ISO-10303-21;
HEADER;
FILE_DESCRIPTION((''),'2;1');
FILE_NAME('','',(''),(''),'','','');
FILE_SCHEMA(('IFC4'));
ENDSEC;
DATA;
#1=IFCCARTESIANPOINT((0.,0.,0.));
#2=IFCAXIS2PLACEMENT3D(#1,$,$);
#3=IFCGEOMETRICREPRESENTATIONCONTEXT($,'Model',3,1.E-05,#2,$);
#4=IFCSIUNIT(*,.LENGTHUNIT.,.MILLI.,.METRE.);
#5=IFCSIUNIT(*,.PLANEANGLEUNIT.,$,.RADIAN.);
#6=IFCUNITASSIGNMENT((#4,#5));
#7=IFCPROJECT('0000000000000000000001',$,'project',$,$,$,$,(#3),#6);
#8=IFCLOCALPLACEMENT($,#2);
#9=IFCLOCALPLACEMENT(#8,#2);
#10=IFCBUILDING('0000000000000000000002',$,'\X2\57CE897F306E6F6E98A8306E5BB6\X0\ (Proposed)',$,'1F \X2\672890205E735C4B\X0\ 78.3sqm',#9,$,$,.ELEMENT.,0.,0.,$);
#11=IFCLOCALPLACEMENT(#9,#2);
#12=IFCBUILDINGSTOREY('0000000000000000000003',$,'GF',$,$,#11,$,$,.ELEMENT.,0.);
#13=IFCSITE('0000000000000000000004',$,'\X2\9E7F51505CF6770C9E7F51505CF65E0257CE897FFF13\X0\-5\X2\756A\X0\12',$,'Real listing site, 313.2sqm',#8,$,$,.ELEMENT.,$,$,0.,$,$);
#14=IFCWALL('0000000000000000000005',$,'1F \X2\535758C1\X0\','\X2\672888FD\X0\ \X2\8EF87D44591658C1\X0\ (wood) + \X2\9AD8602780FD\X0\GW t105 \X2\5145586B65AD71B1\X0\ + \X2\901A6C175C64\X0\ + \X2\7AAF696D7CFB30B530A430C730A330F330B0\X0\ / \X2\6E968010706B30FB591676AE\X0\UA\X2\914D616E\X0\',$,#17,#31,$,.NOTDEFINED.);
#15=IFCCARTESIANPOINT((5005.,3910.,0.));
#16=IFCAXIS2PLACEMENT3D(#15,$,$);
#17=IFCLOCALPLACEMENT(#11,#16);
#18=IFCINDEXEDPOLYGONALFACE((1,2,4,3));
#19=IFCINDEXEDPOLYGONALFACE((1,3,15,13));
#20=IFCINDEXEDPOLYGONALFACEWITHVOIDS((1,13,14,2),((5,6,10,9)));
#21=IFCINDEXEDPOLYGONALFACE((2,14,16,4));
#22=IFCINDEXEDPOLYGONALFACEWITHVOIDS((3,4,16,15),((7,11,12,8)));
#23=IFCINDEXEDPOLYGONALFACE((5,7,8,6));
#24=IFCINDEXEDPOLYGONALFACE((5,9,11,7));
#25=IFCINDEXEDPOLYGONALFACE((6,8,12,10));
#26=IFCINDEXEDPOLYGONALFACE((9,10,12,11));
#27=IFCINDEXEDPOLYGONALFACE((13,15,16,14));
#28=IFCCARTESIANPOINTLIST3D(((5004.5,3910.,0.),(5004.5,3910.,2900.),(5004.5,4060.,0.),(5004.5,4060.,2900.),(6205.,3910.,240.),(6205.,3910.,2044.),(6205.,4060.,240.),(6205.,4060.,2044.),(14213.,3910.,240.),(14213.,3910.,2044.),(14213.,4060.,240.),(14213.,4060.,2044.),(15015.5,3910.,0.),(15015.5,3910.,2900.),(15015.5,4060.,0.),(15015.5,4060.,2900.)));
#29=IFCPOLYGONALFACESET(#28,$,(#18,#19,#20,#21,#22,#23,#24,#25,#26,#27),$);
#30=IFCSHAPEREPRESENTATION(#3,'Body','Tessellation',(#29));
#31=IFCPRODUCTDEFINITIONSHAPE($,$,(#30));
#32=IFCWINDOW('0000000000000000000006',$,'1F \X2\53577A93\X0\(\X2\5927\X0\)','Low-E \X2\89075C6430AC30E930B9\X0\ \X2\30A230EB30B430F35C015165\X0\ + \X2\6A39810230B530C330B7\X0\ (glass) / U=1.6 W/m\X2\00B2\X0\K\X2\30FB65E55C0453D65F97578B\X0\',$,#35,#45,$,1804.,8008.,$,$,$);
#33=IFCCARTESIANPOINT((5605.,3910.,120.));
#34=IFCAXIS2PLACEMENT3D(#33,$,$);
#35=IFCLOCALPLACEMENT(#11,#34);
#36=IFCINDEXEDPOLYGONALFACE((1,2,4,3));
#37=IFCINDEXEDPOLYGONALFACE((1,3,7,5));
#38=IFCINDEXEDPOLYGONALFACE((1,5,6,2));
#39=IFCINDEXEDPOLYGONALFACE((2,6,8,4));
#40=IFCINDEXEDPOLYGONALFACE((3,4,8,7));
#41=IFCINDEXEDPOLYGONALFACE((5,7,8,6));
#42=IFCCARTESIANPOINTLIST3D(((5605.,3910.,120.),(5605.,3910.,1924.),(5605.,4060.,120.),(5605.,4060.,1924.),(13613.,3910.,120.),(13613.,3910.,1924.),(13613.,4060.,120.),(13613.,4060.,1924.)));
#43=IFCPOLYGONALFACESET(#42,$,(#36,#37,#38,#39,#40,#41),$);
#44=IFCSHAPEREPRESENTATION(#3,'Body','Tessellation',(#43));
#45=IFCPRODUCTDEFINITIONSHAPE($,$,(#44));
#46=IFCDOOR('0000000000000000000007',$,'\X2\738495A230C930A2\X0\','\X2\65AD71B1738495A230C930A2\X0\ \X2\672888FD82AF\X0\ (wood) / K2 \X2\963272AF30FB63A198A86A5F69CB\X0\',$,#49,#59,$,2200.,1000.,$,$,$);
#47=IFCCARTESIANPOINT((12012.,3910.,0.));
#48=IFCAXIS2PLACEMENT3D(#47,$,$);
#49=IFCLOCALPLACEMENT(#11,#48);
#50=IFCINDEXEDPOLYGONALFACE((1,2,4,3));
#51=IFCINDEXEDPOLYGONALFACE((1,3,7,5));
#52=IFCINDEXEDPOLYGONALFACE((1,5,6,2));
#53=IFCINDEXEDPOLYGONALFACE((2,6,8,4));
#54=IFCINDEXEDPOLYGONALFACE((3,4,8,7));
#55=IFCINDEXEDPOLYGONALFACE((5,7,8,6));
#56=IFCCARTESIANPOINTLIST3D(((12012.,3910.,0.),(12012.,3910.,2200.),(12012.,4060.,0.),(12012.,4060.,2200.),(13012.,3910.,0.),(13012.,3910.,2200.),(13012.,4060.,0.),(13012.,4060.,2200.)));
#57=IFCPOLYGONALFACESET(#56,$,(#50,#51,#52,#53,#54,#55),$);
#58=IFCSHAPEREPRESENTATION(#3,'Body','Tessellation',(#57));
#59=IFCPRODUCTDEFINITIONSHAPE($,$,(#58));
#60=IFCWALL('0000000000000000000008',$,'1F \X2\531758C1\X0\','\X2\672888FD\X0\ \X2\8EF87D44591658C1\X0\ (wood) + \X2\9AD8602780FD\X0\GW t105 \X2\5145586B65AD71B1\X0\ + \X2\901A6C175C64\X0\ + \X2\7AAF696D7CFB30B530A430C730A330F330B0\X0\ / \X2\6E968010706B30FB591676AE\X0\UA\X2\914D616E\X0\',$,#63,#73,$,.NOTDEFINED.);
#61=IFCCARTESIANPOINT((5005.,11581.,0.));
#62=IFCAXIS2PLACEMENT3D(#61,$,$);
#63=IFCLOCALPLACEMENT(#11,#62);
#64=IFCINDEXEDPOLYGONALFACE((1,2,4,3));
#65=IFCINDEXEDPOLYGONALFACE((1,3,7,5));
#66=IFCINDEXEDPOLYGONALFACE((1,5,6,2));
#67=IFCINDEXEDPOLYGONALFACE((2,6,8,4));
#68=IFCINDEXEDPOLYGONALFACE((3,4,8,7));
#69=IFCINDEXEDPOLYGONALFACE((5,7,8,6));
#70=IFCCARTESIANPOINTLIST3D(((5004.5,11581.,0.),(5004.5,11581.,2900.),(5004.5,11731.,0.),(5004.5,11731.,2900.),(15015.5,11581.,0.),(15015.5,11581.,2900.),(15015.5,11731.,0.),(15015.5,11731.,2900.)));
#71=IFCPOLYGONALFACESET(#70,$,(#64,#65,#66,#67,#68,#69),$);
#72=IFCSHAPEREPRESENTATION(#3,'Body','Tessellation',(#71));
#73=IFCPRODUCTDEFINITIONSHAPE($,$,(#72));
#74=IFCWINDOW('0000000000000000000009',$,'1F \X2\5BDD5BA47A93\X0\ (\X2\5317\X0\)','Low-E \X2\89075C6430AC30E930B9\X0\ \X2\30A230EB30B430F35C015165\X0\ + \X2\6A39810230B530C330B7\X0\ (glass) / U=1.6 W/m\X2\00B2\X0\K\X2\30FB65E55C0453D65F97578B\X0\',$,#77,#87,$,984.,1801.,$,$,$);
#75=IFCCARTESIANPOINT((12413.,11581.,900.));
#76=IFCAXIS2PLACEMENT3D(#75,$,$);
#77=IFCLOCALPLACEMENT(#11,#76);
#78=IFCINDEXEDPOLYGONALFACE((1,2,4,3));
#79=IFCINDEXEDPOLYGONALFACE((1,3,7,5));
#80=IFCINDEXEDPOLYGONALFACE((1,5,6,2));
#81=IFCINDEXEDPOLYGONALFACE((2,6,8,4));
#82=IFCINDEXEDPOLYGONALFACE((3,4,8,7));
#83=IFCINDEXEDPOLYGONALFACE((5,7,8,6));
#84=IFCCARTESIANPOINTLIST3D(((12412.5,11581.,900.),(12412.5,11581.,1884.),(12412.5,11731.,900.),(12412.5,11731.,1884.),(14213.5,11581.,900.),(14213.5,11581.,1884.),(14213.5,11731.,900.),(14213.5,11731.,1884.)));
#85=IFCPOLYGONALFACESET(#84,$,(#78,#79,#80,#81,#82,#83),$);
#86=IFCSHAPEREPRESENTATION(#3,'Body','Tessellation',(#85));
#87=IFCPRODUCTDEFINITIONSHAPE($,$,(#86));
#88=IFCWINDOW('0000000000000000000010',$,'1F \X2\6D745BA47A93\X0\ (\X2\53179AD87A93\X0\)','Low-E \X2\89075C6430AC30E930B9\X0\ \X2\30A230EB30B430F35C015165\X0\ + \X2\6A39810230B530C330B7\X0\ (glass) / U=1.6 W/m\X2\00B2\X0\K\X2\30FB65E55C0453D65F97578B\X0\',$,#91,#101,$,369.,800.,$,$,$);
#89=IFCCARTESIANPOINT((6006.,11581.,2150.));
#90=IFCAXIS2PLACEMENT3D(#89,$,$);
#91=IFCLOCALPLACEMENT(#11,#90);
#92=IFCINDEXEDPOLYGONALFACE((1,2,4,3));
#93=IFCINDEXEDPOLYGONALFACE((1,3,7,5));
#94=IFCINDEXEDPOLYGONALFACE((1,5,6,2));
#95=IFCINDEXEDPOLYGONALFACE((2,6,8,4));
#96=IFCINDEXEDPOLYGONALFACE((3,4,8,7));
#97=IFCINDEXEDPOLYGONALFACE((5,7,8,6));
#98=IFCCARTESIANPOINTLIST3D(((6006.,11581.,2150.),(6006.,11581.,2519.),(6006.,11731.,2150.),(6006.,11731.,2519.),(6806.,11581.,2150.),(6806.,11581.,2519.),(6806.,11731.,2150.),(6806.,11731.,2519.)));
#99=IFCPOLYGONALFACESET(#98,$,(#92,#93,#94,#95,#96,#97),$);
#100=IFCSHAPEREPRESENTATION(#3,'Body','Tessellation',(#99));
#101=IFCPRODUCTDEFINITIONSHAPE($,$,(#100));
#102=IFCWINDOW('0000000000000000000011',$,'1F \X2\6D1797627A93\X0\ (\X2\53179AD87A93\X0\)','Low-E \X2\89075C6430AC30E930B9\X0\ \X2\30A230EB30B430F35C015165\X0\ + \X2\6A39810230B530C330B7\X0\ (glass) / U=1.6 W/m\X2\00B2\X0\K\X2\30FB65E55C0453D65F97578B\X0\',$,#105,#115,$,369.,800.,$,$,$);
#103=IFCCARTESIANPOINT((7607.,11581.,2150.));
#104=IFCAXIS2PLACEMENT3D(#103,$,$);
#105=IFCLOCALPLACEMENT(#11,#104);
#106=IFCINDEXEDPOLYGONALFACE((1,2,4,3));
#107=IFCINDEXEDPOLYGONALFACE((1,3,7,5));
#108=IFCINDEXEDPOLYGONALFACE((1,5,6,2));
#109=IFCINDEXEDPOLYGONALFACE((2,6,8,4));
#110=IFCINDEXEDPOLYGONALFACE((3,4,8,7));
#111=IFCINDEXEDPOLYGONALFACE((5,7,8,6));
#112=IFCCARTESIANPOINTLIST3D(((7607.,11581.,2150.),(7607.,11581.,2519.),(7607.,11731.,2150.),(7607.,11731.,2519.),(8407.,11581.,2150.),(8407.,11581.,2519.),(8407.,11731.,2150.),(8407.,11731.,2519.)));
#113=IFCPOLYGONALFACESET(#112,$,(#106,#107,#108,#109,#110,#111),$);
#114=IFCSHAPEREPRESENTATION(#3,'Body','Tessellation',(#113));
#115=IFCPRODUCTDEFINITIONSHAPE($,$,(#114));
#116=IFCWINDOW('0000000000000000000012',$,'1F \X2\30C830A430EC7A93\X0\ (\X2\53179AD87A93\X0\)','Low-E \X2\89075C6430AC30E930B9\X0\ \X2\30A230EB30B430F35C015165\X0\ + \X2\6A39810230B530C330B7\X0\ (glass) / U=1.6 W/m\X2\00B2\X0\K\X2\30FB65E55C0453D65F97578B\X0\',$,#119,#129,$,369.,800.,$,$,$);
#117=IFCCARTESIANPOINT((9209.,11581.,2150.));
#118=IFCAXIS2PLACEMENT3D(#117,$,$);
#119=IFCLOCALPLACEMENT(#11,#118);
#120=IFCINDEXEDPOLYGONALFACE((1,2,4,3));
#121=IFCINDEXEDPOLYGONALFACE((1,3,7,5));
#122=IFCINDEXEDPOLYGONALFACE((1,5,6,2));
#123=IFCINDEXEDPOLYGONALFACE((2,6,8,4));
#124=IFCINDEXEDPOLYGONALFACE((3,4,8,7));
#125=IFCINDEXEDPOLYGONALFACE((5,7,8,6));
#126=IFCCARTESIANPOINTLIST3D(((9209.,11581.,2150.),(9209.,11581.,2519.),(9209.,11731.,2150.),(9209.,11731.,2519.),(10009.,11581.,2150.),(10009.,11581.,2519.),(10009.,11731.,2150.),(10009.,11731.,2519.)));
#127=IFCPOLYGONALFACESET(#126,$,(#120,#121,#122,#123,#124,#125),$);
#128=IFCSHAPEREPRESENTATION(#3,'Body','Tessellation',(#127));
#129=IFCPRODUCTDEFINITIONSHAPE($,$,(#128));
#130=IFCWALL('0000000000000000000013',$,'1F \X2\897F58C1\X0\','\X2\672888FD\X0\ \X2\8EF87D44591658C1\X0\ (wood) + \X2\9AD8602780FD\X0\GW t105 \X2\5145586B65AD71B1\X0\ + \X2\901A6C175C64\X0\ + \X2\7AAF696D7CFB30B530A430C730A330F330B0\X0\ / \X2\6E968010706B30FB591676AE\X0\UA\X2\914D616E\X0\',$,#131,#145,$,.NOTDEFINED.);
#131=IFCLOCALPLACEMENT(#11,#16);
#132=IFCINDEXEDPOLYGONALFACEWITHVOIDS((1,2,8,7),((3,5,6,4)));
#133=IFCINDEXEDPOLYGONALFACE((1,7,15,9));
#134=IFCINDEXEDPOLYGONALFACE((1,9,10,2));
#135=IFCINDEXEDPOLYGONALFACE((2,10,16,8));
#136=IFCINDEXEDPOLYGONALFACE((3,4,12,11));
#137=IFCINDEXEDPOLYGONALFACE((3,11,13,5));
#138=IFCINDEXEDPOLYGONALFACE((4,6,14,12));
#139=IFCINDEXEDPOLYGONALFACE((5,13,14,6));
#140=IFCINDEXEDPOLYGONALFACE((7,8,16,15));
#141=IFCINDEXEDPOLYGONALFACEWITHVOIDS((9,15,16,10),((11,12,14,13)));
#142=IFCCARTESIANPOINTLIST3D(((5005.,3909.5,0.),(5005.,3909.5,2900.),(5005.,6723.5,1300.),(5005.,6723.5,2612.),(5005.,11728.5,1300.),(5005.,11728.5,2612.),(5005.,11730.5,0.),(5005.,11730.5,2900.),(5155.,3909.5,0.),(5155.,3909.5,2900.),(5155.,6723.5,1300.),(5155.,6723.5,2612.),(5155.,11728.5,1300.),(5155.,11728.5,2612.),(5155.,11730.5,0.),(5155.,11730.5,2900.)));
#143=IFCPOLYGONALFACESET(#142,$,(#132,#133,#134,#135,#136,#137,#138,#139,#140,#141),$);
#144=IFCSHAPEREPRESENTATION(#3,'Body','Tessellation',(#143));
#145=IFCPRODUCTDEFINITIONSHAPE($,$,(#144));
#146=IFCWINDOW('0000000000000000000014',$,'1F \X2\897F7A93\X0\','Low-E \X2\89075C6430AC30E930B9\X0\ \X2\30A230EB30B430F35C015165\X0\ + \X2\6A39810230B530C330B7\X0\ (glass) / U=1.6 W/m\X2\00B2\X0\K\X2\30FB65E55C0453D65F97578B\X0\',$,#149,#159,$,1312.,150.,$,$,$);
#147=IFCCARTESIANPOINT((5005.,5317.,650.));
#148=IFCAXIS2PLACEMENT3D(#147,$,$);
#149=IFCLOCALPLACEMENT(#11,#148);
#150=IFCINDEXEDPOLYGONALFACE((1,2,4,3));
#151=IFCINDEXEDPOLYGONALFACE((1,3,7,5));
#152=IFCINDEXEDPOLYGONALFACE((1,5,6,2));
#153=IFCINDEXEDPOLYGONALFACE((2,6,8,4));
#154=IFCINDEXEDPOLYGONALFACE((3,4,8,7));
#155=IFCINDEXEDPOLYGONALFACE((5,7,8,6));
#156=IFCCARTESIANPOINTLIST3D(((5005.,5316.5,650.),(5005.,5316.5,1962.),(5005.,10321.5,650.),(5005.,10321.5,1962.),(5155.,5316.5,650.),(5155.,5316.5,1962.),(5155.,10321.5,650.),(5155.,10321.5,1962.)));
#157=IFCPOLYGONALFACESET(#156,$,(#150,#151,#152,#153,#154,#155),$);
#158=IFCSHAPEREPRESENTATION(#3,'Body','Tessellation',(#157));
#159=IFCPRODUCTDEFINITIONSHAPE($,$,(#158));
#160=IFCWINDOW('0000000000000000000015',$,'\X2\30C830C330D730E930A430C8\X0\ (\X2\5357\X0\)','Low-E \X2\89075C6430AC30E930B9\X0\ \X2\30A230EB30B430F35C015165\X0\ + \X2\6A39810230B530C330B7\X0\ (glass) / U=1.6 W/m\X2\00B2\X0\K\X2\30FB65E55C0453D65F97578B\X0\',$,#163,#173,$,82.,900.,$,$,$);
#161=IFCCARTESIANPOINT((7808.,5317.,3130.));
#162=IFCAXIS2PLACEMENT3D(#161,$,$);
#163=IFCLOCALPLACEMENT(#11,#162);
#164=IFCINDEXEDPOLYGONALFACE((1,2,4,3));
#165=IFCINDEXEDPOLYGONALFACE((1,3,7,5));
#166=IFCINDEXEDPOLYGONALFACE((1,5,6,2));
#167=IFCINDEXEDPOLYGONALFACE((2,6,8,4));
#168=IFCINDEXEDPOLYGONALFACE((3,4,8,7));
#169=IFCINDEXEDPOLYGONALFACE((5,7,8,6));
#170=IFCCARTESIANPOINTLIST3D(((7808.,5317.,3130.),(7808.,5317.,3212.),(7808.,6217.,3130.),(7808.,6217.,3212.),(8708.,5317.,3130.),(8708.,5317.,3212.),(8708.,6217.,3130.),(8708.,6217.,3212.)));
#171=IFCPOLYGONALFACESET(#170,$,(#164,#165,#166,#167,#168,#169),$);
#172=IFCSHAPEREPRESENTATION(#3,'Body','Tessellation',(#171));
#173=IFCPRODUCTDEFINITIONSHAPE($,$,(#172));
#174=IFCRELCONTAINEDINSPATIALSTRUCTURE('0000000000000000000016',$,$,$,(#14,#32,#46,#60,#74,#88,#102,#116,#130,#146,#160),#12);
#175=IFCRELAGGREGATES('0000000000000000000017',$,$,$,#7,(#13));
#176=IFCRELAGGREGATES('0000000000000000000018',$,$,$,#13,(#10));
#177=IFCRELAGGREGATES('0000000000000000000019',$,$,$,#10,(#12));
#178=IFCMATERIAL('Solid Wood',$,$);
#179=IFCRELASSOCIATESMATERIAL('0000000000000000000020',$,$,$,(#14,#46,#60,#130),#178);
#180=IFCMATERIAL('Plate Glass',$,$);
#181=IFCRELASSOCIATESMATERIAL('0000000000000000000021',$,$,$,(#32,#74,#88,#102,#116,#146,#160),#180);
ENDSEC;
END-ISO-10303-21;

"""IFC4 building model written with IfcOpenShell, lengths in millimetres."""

from ifc_helpers import new_model, si_unit, frame, frame_2d, origin, place, context, project, spatial, rectangle, extrude, material, element, fill, save


model = new_model("IFC4")

# Units and contexts
model_context = context("Model", 3, precision=1e-05, world=origin())
ifc_project = project(units=[si_unit("LENGTHUNIT", "METRE", prefix="MILLI"), si_unit("PLANEANGLEUNIT", "RADIAN")], contexts=[model_context])

# Site, building, storey
site_placement = place(None, origin())
site = spatial("IfcSite", under=ifc_project, at=site_placement, Name="鹿児島県鹿児島市城西３-5番12", ObjectType="Real listing site, 313.2sqm", CompositionType="ELEMENT", RefElevation=0.0)
building_placement = place(site_placement, origin())
building = spatial("IfcBuilding", under=site, at=building_placement, Name="城西の潮風の家 (Proposed)", ObjectType="1F 木造平屋 78.3sqm", CompositionType="ELEMENT", ElevationOfRefHeight=0.0, ElevationOfTerrain=0.0)
storey_placement = place(building_placement, origin())
storey = spatial("IfcBuildingStorey", under=building, at=storey_placement, Name="GF", CompositionType="ELEMENT", Elevation=0.0)

# Shared definitions
ifc_material_1 = material(Name="Solid Wood")

# Wall, openings, window, door
wall_1_placement = place(storey_placement, frame((5005.0, 3910.0, 0.0)))
wall_1 = element("IfcWall", 1, at=wall_1_placement, inside=storey, material=ifc_material_1, Name="1F 南壁", Description="木製 軸組外壁 (wood) + 高性能GW t105 充填断熱 + 通気層 + 窯業系サイディング / 準耐火・外皮UA配慮", PredefinedType="NOTDEFINED", context=model_context, shape_type="SweptSolid", body=[
    extrude(rectangle(XDim=10011.0, YDim=150.0, at=frame_2d((5005.0, 75.0))), frame((5005.0, 3910.0, 0.0)), (0.0, 0.0, 1.0), 2900.0),
])
opening_1_placement = place(storey_placement, frame((5605.0, 3910.0, 120.0)))
opening_1 = element("IfcOpeningElement", 2, at=opening_1_placement, cuts=wall_1, PredefinedType="NOTDEFINED", context=model_context, shape_type="SweptSolid", body=[
    extrude(rectangle(XDim=8008.0, YDim=150.0, at=frame_2d((4004.0, 75.0))), frame((5605.0, 3910.0, 120.0)), (0.0, 0.0, 1.0), 1804.0),
])
opening_2_placement = place(storey_placement, frame((12012.0, 3910.0, 0.0)))
opening_2 = element("IfcOpeningElement", 3, at=opening_2_placement, cuts=wall_1, PredefinedType="NOTDEFINED", context=model_context, shape_type="SweptSolid", body=[
    extrude(rectangle(XDim=1000.0, YDim=150.0, at=frame_2d((500.0, 75.0))), frame((12012.0, 3910.0, 0.0)), (0.0, 0.0, 1.0), 2200.0),
])
ifc_material_2 = material(Name="Plate Glass")
window_1_placement = place(storey_placement, frame((5605.0, 3910.0, 120.0)))
window_1 = element("IfcWindow", 4, at=window_1_placement, inside=storey, material=ifc_material_2, Name="1F 南窓(大)", Description="Low-E 複層ガラス アルゴン封入 + 樹脂サッシ (glass) / U=1.6 W/m²K・日射取得型", OverallHeight=1804.0, OverallWidth=8008.0, context=model_context, shape_type="SweptSolid", body=[
    extrude(rectangle(XDim=8008.0, YDim=150.0, at=frame_2d((4004.0, 75.0))), frame((5605.0, 3910.0, 120.0)), (0.0, 0.0, 1.0), 1804.0),
])
fill(opening_1, window_1)
door_1_placement = place(storey_placement, frame((12012.0, 3910.0, 0.0)))
door_1 = element("IfcDoor", 5, at=door_1_placement, inside=storey, material=ifc_material_1, Name="玄関ドア", Description="断熱玄関ドア 木製芯 (wood) / K2 防犯・採風機構", OverallHeight=2200.0, OverallWidth=1000.0, context=model_context, shape_type="SweptSolid", body=[
    extrude(rectangle(XDim=1000.0, YDim=150.0, at=frame_2d((500.0, 75.0))), frame((12012.0, 3910.0, 0.0)), (0.0, 0.0, 1.0), 2200.0),
])
fill(opening_2, door_1)

# Wall, openings, windows
wall_2_placement = place(storey_placement, frame((5005.0, 11581.0, 0.0)))
wall_2 = element("IfcWall", 6, at=wall_2_placement, inside=storey, material=ifc_material_1, Name="1F 北壁", Description="木製 軸組外壁 (wood) + 高性能GW t105 充填断熱 + 通気層 + 窯業系サイディング / 準耐火・外皮UA配慮", PredefinedType="NOTDEFINED", context=model_context, shape_type="SweptSolid", body=[
    extrude(rectangle(XDim=10011.0, YDim=150.0, at=frame_2d((5005.0, 75.0))), frame((5005.0, 11581.0, 0.0)), (0.0, 0.0, 1.0), 2900.0),
])
opening_3_placement = place(storey_placement, frame((12413.0, 11581.0, 900.0)))
opening_3 = element("IfcOpeningElement", 7, at=opening_3_placement, cuts=wall_2, PredefinedType="NOTDEFINED", context=model_context, shape_type="SweptSolid", body=[
    extrude(rectangle(XDim=1801.0, YDim=150.0, at=frame_2d((900.0, 75.0))), frame((12413.0, 11581.0, 900.0)), (0.0, 0.0, 1.0), 984.0),
])
opening_4_placement = place(storey_placement, frame((6006.0, 11581.0, 2150.0)))
opening_4 = element("IfcOpeningElement", 8, at=opening_4_placement, cuts=wall_2, PredefinedType="NOTDEFINED", context=model_context, shape_type="SweptSolid", body=[
    extrude(rectangle(XDim=800.0, YDim=150.0, at=frame_2d((400.0, 75.0))), frame((6006.0, 11581.0, 2150.0)), (0.0, 0.0, 1.0), 369.0),
])
opening_5_placement = place(storey_placement, frame((7607.0, 11581.0, 2150.0)))
opening_5 = element("IfcOpeningElement", 9, at=opening_5_placement, cuts=wall_2, PredefinedType="NOTDEFINED", context=model_context, shape_type="SweptSolid", body=[
    extrude(rectangle(XDim=800.0, YDim=150.0, at=frame_2d((400.0, 75.0))), frame((7607.0, 11581.0, 2150.0)), (0.0, 0.0, 1.0), 369.0),
])
opening_6_placement = place(storey_placement, frame((9209.0, 11581.0, 2150.0)))
opening_6 = element("IfcOpeningElement", 10, at=opening_6_placement, cuts=wall_2, PredefinedType="NOTDEFINED", context=model_context, shape_type="SweptSolid", body=[
    extrude(rectangle(XDim=800.0, YDim=150.0, at=frame_2d((400.0, 75.0))), frame((9209.0, 11581.0, 2150.0)), (0.0, 0.0, 1.0), 369.0),
])
window_2_placement = place(storey_placement, frame((12413.0, 11581.0, 900.0)))
window_2 = element("IfcWindow", 11, at=window_2_placement, inside=storey, material=ifc_material_2, Name="1F 寝室窓 (北)", Description="Low-E 複層ガラス アルゴン封入 + 樹脂サッシ (glass) / U=1.6 W/m²K・日射取得型", OverallHeight=984.0, OverallWidth=1801.0, context=model_context, shape_type="SweptSolid", body=[
    extrude(rectangle(XDim=1801.0, YDim=150.0, at=frame_2d((900.0, 75.0))), frame((12413.0, 11581.0, 900.0)), (0.0, 0.0, 1.0), 984.0),
])
fill(opening_3, window_2)
window_3_placement = place(storey_placement, frame((6006.0, 11581.0, 2150.0)))
window_3 = element("IfcWindow", 12, at=window_3_placement, inside=storey, material=ifc_material_2, Name="1F 浴室窓 (北高窓)", Description="Low-E 複層ガラス アルゴン封入 + 樹脂サッシ (glass) / U=1.6 W/m²K・日射取得型", OverallHeight=369.0, OverallWidth=800.0, context=model_context, shape_type="SweptSolid", body=[
    extrude(rectangle(XDim=800.0, YDim=150.0, at=frame_2d((400.0, 75.0))), frame((6006.0, 11581.0, 2150.0)), (0.0, 0.0, 1.0), 369.0),
])
fill(opening_4, window_3)
window_4_placement = place(storey_placement, frame((7607.0, 11581.0, 2150.0)))
window_4 = element("IfcWindow", 13, at=window_4_placement, inside=storey, material=ifc_material_2, Name="1F 洗面窓 (北高窓)", Description="Low-E 複層ガラス アルゴン封入 + 樹脂サッシ (glass) / U=1.6 W/m²K・日射取得型", OverallHeight=369.0, OverallWidth=800.0, context=model_context, shape_type="SweptSolid", body=[
    extrude(rectangle(XDim=800.0, YDim=150.0, at=frame_2d((400.0, 75.0))), frame((7607.0, 11581.0, 2150.0)), (0.0, 0.0, 1.0), 369.0),
])
fill(opening_5, window_4)
window_5_placement = place(storey_placement, frame((9209.0, 11581.0, 2150.0)))
window_5 = element("IfcWindow", 14, at=window_5_placement, inside=storey, material=ifc_material_2, Name="1F トイレ窓 (北高窓)", Description="Low-E 複層ガラス アルゴン封入 + 樹脂サッシ (glass) / U=1.6 W/m²K・日射取得型", OverallHeight=369.0, OverallWidth=800.0, context=model_context, shape_type="SweptSolid", body=[
    extrude(rectangle(XDim=800.0, YDim=150.0, at=frame_2d((400.0, 75.0))), frame((9209.0, 11581.0, 2150.0)), (0.0, 0.0, 1.0), 369.0),
])
fill(opening_6, window_5)

# Wall, opening, window
wall_3_placement = place(storey_placement, frame((5005.0, 3910.0, 0.0)))
wall_3 = element("IfcWall", 15, at=wall_3_placement, inside=storey, material=ifc_material_1, Name="1F 西壁", Description="木製 軸組外壁 (wood) + 高性能GW t105 充填断熱 + 通気層 + 窯業系サイディング / 準耐火・外皮UA配慮", PredefinedType="NOTDEFINED", context=model_context, shape_type="SweptSolid", body=[
    extrude(rectangle(XDim=150.0, YDim=7821.0, at=frame_2d((75.0, 3910.0))), frame((5005.0, 3910.0, 0.0)), (0.0, 0.0, 1.0), 2900.0),
])
opening_7_placement = place(storey_placement, frame((5005.0, 5317.0, 650.0)))
opening_7 = element("IfcOpeningElement", 16, at=opening_7_placement, cuts=wall_3, PredefinedType="NOTDEFINED", context=model_context, shape_type="SweptSolid", body=[
    extrude(rectangle(XDim=150.0, YDim=5005.0, at=frame_2d((75.0, 2502.0))), frame((5005.0, 5317.0, 650.0)), (0.0, 0.0, 1.0), 1312.0),
])
window_6_placement = place(storey_placement, frame((5005.0, 5317.0, 650.0)))
window_6 = element("IfcWindow", 17, at=window_6_placement, inside=storey, material=ifc_material_2, Name="1F 西窓", Description="Low-E 複層ガラス アルゴン封入 + 樹脂サッシ (glass) / U=1.6 W/m²K・日射取得型", OverallHeight=1312.0, OverallWidth=150.0, context=model_context, shape_type="SweptSolid", body=[
    extrude(rectangle(XDim=150.0, YDim=5005.0, at=frame_2d((75.0, 2502.0))), frame((5005.0, 5317.0, 650.0)), (0.0, 0.0, 1.0), 1312.0),
])
fill(opening_7, window_6)

# Window
window_7_placement = place(storey_placement, frame((7808.0, 5317.0, 3130.0)))
element("IfcWindow", 18, at=window_7_placement, inside=storey, material=ifc_material_2, Name="トップライト (南)", Description="Low-E 複層ガラス アルゴン封入 + 樹脂サッシ (glass) / U=1.6 W/m²K・日射取得型", OverallHeight=82.0, OverallWidth=900.0, context=model_context, shape_type="SweptSolid", body=[
    extrude(rectangle(XDim=900.0, YDim=900.0, at=frame_2d((450.0, 450.0))), frame((7808.0, 5317.0, 3130.0)), (0.0, 0.0, 1.0), 82.0),
])

save(model, "model.ifc")
